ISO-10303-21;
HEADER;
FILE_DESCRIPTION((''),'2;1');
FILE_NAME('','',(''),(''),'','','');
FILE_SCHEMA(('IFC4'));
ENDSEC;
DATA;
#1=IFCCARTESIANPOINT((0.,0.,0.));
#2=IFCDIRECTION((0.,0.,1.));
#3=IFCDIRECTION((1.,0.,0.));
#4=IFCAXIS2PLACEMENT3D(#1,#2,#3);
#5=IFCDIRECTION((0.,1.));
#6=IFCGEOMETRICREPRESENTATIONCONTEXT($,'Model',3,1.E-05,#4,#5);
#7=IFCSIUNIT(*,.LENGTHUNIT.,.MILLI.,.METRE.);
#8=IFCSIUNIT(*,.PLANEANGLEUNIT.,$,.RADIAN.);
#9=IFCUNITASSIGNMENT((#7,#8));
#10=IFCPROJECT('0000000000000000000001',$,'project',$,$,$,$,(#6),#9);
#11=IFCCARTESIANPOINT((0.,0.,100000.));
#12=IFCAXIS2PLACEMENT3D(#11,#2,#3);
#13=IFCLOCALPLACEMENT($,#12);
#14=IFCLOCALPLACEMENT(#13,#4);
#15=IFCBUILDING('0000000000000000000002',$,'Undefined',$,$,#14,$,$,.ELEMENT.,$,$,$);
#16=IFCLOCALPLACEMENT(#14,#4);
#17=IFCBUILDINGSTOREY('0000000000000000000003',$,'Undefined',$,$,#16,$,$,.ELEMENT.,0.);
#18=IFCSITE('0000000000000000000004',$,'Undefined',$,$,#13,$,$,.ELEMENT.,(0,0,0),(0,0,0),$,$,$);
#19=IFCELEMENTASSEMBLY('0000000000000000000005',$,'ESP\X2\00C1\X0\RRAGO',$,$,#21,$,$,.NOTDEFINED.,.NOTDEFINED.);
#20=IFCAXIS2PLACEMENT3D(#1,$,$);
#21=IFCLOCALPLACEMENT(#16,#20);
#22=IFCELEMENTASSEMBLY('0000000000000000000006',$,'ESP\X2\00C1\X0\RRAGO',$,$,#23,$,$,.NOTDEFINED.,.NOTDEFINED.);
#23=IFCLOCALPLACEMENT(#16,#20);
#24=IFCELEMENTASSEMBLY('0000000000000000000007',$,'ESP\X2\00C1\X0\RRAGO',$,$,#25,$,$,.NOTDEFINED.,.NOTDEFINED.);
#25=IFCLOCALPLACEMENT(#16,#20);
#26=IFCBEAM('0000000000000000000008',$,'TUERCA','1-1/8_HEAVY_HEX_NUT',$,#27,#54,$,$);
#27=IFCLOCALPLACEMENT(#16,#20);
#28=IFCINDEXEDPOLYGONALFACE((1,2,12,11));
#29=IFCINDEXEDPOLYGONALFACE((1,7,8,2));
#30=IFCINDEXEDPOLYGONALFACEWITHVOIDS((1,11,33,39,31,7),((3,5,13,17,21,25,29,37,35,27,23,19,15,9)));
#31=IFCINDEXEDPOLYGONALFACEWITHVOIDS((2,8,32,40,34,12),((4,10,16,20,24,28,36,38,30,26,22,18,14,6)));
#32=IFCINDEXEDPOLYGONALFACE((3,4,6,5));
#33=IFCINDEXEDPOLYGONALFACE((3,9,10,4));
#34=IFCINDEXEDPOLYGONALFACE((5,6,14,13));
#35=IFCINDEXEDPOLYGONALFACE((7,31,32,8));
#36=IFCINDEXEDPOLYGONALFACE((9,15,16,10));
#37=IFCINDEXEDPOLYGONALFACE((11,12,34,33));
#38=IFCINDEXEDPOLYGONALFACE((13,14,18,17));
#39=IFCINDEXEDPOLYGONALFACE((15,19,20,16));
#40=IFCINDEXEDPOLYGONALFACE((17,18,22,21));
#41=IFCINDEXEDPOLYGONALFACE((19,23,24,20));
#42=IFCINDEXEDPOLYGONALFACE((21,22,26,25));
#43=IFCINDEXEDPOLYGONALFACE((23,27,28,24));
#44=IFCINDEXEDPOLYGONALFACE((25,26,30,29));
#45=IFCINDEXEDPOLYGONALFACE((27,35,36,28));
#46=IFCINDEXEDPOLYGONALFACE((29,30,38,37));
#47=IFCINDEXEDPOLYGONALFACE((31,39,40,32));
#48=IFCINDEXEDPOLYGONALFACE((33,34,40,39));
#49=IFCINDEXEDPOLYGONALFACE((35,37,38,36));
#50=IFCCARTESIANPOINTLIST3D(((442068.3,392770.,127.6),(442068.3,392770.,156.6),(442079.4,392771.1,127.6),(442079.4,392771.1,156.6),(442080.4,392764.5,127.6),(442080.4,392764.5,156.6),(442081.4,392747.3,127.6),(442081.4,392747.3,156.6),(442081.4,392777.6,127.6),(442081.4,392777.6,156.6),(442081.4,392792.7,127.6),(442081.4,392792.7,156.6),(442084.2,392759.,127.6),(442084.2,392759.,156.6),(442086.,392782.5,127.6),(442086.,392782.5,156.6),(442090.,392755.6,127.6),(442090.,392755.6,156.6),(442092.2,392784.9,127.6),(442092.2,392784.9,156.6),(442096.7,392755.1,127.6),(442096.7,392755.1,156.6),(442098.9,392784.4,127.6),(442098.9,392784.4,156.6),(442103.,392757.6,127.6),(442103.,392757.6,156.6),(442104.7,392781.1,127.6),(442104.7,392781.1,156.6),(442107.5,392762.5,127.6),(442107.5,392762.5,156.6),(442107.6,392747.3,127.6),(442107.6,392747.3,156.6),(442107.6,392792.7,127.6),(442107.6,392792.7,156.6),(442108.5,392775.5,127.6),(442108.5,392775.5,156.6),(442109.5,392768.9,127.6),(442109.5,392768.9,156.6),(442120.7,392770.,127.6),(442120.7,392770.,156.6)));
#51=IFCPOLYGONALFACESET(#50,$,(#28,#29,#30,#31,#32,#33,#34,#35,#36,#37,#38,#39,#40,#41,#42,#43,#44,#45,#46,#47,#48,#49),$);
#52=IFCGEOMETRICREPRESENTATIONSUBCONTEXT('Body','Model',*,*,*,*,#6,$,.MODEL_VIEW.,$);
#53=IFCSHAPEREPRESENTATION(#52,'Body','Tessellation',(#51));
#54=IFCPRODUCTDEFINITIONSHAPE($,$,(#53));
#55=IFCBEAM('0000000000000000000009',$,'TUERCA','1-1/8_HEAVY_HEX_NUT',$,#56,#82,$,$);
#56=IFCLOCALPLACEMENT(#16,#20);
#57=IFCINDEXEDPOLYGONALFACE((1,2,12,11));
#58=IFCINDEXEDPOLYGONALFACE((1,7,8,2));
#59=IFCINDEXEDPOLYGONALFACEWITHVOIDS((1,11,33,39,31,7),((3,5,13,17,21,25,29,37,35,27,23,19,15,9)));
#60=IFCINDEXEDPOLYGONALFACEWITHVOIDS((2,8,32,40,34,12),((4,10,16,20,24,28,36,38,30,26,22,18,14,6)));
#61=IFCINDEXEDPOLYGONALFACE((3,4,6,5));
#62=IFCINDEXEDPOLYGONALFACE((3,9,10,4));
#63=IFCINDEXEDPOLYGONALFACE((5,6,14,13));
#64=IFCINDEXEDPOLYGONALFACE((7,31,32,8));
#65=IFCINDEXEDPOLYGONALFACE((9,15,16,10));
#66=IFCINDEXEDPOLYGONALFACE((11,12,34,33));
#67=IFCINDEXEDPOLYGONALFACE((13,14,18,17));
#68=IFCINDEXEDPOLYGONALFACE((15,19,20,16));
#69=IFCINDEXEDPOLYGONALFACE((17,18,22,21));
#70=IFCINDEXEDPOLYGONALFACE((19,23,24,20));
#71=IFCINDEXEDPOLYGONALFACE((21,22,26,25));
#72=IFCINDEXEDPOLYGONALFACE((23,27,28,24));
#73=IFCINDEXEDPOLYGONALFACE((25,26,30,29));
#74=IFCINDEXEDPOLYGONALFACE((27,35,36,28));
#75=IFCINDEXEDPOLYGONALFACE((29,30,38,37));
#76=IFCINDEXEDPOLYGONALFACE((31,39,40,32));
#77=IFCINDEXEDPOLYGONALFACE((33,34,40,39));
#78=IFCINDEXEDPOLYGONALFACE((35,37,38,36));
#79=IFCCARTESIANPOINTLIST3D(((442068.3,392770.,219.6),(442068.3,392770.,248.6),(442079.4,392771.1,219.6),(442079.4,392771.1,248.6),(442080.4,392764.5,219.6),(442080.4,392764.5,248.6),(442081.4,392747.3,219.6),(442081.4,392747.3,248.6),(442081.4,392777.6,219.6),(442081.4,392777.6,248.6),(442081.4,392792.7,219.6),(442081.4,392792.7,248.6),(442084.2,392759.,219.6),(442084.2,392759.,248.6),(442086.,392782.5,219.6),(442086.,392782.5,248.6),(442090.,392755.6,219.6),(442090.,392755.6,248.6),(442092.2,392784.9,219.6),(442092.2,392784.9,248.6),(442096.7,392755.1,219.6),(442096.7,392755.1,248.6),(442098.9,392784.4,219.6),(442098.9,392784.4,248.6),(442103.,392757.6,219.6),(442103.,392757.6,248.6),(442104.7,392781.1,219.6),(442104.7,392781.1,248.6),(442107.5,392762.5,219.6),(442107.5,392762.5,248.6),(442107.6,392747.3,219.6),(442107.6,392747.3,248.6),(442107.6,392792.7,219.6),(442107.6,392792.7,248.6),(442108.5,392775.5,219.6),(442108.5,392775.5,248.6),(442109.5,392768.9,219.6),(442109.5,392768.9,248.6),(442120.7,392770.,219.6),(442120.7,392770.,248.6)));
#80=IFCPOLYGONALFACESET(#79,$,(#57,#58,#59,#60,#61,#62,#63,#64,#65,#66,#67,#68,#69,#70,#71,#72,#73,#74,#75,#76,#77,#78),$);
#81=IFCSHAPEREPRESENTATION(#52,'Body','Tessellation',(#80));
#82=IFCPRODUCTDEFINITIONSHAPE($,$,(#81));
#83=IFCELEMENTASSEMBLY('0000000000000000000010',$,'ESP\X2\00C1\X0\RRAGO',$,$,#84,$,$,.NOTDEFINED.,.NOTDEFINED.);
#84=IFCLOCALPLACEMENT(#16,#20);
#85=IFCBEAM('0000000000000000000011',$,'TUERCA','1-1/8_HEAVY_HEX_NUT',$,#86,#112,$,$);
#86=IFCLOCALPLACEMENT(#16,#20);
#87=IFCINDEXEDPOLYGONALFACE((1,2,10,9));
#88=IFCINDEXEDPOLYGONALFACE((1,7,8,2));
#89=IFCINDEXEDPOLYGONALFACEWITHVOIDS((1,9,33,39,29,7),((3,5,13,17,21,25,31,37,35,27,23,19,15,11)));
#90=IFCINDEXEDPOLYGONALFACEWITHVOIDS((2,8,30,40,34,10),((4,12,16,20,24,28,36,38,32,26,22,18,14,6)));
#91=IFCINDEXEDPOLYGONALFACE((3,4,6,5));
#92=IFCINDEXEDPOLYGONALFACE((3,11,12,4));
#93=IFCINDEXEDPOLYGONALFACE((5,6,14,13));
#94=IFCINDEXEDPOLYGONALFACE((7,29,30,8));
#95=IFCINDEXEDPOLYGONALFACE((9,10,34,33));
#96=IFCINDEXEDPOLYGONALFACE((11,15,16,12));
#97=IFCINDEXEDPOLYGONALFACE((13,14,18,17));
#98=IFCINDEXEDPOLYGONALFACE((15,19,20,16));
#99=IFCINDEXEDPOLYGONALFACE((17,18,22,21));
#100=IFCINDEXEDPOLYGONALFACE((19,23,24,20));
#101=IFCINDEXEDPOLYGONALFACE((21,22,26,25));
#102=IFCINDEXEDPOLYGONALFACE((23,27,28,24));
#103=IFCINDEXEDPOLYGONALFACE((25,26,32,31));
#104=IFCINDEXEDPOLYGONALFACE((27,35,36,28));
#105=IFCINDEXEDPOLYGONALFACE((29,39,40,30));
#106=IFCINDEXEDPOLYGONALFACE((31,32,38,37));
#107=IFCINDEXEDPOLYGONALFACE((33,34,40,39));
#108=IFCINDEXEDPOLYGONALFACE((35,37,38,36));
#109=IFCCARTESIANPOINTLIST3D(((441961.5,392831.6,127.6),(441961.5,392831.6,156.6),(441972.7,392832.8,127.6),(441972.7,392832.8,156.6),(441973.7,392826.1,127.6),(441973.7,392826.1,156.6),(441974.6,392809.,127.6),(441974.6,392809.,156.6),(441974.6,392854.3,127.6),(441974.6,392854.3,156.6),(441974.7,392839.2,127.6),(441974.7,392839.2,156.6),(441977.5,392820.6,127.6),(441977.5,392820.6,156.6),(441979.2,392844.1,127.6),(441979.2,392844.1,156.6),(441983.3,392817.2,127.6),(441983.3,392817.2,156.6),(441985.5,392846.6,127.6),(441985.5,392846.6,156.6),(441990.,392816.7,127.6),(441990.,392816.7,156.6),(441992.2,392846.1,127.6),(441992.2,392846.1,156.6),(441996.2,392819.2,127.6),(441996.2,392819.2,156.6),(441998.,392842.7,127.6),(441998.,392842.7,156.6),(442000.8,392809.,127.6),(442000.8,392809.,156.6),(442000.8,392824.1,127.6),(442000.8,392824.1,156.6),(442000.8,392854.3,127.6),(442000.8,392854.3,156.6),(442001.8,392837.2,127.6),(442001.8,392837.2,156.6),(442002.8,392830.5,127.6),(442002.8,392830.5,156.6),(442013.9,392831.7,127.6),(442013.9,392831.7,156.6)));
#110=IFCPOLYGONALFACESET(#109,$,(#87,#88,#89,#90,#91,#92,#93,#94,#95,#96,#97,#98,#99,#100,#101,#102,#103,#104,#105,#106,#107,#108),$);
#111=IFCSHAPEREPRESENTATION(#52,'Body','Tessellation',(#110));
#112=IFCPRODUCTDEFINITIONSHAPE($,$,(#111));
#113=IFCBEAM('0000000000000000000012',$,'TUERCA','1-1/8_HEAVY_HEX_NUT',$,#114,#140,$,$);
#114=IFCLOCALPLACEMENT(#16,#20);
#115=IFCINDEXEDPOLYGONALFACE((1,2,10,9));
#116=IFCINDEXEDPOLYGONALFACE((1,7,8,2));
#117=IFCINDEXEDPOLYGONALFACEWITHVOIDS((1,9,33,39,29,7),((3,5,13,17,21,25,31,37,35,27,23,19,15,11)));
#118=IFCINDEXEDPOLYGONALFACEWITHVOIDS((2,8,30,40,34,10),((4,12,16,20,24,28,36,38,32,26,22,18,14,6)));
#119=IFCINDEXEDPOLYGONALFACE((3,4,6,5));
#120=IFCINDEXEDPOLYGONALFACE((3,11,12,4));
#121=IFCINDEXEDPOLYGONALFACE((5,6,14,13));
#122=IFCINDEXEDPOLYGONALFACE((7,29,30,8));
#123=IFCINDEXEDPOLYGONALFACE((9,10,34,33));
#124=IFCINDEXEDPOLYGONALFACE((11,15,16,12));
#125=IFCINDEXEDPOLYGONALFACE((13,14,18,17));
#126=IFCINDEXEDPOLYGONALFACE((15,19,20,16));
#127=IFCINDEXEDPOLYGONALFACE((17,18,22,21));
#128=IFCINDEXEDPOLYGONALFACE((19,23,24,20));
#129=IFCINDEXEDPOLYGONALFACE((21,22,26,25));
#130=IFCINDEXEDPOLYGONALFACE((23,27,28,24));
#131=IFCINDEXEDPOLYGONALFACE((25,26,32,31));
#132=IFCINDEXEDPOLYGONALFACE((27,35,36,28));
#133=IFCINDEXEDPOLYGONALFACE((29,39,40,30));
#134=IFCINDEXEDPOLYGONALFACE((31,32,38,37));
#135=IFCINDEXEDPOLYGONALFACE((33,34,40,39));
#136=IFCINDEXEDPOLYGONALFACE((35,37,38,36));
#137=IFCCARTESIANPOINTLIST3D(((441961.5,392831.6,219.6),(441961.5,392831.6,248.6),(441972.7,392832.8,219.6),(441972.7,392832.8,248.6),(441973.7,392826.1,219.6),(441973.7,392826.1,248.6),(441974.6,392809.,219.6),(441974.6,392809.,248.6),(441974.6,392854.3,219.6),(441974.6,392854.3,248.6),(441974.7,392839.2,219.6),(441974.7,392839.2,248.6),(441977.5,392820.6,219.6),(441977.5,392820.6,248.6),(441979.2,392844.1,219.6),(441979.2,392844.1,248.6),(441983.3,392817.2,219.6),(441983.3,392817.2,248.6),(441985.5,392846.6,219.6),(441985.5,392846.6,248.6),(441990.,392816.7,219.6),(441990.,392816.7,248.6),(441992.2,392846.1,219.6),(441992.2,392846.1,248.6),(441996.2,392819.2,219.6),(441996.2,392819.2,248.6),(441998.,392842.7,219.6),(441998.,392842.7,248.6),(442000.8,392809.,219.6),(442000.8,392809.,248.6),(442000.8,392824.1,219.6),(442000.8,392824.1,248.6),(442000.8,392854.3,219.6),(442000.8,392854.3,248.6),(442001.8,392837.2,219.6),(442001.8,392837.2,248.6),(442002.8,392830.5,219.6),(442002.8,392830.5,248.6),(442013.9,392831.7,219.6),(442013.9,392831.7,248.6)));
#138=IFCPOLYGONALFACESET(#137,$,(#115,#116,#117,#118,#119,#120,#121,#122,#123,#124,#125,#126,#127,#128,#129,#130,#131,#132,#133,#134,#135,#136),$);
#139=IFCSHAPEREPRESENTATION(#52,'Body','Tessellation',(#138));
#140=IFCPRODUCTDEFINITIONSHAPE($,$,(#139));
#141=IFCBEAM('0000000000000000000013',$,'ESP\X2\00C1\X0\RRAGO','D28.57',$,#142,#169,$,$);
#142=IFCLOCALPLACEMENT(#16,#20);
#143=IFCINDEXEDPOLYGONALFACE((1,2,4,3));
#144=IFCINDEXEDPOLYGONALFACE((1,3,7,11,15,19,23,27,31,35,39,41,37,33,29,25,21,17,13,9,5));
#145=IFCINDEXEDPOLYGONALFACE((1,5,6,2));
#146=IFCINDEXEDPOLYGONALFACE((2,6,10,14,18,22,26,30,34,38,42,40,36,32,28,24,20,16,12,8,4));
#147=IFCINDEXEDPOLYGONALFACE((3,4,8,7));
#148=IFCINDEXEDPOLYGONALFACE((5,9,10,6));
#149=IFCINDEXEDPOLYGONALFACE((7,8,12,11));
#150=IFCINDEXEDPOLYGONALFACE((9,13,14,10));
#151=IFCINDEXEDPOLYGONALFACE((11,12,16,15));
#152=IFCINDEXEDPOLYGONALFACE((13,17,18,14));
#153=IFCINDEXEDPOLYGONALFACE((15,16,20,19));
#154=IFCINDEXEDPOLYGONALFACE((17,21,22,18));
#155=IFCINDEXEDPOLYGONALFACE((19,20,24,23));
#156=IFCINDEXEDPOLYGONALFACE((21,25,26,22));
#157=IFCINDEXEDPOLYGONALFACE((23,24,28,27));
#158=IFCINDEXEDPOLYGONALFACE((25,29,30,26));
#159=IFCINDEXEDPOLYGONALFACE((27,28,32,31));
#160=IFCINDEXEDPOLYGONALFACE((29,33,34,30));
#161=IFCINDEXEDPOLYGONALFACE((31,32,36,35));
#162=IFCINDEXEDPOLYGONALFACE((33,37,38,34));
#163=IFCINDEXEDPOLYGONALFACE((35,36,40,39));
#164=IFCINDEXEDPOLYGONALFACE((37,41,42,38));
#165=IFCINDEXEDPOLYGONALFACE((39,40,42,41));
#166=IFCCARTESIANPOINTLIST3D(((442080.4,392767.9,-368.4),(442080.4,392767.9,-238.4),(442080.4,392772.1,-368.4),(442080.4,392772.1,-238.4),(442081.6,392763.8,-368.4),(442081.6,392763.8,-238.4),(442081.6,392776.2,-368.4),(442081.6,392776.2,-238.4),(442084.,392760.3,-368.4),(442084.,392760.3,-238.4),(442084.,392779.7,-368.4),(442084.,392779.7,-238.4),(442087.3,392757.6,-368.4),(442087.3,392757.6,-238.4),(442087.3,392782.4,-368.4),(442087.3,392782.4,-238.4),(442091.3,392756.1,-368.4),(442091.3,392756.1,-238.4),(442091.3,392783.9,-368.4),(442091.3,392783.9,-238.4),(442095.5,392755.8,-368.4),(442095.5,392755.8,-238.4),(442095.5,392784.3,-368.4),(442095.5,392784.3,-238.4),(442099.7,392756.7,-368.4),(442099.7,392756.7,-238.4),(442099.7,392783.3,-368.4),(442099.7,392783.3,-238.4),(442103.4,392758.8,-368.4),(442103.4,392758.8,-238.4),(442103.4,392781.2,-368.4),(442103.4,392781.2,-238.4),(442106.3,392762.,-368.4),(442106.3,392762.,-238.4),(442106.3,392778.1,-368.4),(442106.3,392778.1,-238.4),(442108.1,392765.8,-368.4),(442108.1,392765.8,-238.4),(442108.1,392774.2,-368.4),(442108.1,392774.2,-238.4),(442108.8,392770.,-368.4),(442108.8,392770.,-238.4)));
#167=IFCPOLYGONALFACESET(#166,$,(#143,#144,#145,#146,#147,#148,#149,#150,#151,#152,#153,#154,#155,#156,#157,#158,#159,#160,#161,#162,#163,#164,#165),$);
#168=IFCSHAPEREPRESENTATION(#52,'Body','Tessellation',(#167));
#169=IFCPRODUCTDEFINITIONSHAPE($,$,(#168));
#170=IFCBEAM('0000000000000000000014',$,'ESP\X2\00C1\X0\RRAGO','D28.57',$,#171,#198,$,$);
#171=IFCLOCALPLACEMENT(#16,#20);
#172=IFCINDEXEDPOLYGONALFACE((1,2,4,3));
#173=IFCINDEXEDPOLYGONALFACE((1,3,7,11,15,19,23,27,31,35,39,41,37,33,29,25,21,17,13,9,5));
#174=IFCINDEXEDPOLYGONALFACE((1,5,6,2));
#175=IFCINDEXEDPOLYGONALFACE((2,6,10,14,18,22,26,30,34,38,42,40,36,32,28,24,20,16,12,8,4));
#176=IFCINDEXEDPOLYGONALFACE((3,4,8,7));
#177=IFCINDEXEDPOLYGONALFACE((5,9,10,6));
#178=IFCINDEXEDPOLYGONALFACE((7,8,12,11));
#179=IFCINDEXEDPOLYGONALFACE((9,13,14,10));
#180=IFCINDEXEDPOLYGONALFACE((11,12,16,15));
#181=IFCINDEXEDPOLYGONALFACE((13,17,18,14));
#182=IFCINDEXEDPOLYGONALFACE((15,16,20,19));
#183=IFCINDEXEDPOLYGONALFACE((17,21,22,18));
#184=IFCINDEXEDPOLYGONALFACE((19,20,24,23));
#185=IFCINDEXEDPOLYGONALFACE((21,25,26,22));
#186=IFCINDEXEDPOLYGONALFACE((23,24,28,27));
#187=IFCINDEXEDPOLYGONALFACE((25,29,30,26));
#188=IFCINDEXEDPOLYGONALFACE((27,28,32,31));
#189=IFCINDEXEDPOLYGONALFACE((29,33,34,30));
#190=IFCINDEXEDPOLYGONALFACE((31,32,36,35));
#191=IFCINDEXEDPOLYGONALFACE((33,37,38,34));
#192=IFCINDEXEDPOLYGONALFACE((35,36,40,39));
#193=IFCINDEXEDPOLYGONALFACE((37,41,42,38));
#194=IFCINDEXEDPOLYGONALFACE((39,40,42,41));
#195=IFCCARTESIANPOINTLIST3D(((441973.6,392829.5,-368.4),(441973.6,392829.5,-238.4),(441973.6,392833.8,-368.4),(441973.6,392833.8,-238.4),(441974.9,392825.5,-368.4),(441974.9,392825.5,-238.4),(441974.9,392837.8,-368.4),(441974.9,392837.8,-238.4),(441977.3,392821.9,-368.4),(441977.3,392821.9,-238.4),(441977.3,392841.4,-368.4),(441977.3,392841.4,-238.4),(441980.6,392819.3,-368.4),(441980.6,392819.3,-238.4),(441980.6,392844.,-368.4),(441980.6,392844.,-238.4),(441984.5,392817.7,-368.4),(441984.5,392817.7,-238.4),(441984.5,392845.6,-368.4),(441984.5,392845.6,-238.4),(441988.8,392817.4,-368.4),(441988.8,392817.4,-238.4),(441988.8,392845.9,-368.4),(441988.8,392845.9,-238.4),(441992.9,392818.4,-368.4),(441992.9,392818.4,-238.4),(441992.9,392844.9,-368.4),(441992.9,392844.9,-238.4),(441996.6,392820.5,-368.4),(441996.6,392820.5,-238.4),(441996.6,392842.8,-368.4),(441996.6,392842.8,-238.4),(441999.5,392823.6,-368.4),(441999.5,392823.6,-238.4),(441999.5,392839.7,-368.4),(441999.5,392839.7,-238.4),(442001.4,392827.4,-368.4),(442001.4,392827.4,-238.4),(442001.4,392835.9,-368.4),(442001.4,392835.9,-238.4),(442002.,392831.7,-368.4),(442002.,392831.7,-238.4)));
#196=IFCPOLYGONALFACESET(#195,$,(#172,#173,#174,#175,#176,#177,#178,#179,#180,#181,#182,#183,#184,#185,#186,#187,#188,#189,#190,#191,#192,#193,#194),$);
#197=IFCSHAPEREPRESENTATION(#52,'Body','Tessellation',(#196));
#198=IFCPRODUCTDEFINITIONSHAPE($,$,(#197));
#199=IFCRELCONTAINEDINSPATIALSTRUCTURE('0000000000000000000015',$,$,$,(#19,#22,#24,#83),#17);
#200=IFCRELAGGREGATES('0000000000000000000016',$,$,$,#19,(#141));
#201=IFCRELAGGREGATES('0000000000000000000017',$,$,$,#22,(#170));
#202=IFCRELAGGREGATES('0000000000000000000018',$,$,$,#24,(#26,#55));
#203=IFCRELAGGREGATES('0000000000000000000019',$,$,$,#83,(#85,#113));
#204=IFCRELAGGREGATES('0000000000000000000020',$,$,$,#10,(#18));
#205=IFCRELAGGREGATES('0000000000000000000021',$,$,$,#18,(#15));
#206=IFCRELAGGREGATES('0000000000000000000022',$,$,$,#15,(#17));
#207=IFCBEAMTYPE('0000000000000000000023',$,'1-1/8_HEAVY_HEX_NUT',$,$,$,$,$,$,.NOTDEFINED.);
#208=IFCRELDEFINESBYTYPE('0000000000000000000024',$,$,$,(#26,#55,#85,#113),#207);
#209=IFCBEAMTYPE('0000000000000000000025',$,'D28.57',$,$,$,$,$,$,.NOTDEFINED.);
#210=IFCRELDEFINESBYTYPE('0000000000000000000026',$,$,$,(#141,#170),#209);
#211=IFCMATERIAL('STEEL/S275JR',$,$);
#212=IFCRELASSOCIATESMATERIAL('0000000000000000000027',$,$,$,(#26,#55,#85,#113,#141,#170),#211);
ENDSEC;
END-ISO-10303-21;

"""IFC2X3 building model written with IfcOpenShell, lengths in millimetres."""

from ifc_helpers import new_model, si_unit, direction, frame, origin_with_axes, origin_2d_with_axis, place, context, subcontext, project, spatial, polyline, circle, outline, extrude, material, type_object, element, aggregate, save


model = new_model("IFC2X3")

# Units and contexts
model_context = context("Model", 3, precision=1e-05, world=origin_with_axes(), true_north=direction((0.0, 1.0)))
body_context = subcontext(model_context, "Body", "Model", "MODEL_VIEW")
ifc_project = project(units=[si_unit("LENGTHUNIT", "METRE", prefix="MILLI"), si_unit("PLANEANGLEUNIT", "RADIAN")], contexts=[model_context])

# Site, building, storey
site_placement = place(None, frame((0.0, 0.0, 100000.0), z_axis=(0.0, 0.0, 1.0), x_axis=(1.0, 0.0, 0.0)))
site = spatial("IfcSite", under=ifc_project, at=site_placement, Name="Undefined", CompositionType="ELEMENT", RefLatitude=(0, 0, 0), RefLongitude=(0, 0, 0))
building_placement = place(site_placement, origin_with_axes())
building = spatial("IfcBuilding", under=site, at=building_placement, Name="Undefined", CompositionType="ELEMENT")
storey_placement = place(building_placement, origin_with_axes())
storey = spatial("IfcBuildingStorey", under=building, at=storey_placement, Name="Undefined", CompositionType="ELEMENT", Elevation=0.0)

# Shared definitions
ifc_material_1 = material(Name="STEEL/S275JR")

# Element assemblies
assembly_1_placement = place(storey_placement, origin_with_axes())
assembly_1 = element("IfcElementAssembly", 1, at=assembly_1_placement, inside=storey, Name="ESPÁRRAGO", AssemblyPlace="NOTDEFINED", PredefinedType="NOTDEFINED")
beam_type_1 = type_object("IfcBeamType", Name="1-1/8_HEAVY_HEX_NUT", PredefinedType="NOTDEFINED")
assembly_2_placement = place(storey_placement, origin_with_axes())
assembly_2 = element("IfcElementAssembly", 2, at=assembly_2_placement, inside=storey, Name="ESPÁRRAGO", AssemblyPlace="NOTDEFINED", PredefinedType="NOTDEFINED")

# Element assemblies, beams
assembly_3_placement = place(storey_placement, origin_with_axes())
assembly_3 = element("IfcElementAssembly", 3, at=assembly_3_placement, inside=storey, Name="ESPÁRRAGO", AssemblyPlace="NOTDEFINED", PredefinedType="NOTDEFINED")
beam_1_placement = place(assembly_3_placement, frame((442094.5, 392770.0, 156.6), z_axis=(0.866025, -0.5, 0.0), x_axis=(0.0, 0.0, -1.0)))
beam_1 = element("IfcBeam", 4, at=beam_1_placement, type_object=beam_type_1, material=ifc_material_1, Name="TUERCA", Description="1-1/8_HEAVY_HEX_NUT", context=body_context, shape_type="SweptSolid", body=[
    extrude(outline(polyline([(-13.1, -22.7), (-26.2, 0.0), (-13.1, 22.7), (13.1, 22.7), (26.2, 0.0), (13.1, -22.7), (-13.1, -22.7)]), holes=[polyline([(6.5, 13.6), (0.0, 15.1), (-6.5, 13.6), (-11.8, 9.4), (-14.7, 3.4), (-14.7, -3.4), (-11.8, -9.4), (-6.5, -13.6), (0.0, -15.1), (6.5, -13.6), (11.8, -9.4), (14.7, -3.4), (14.7, 3.4), (11.8, 9.4), (6.5, 13.6)])]), frame((29.0, 0.0, 0.0), z_axis=(-1.0, 0.0, 0.0), x_axis=(0.0, -1.0, 0.0)), (0.0, 0.0, 1.0), 29.0),
])
beam_2_placement = place(assembly_3_placement, frame((442094.5, 392770.0, 248.6), z_axis=(0.866025, -0.5, 0.0), x_axis=(0.0, 0.0, -1.0)))
beam_2 = element("IfcBeam", 5, at=beam_2_placement, type_object=beam_type_1, material=ifc_material_1, Name="TUERCA", Description="1-1/8_HEAVY_HEX_NUT", context=body_context, shape_type="SweptSolid", body=[
    extrude(outline(polyline([(-13.1, -22.7), (-26.2, 0.0), (-13.1, 22.7), (13.1, 22.7), (26.2, 0.0), (13.1, -22.7), (-13.1, -22.7)]), holes=[polyline([(6.5, 13.6), (0.0, 15.1), (-6.5, 13.6), (-11.8, 9.4), (-14.7, 3.4), (-14.7, -3.4), (-11.8, -9.4), (-6.5, -13.6), (0.0, -15.1), (6.5, -13.6), (11.8, -9.4), (14.7, -3.4), (14.7, 3.4), (11.8, 9.4), (6.5, 13.6)])]), frame((29.0, 0.0, 0.0), z_axis=(-1.0, 0.0, 0.0), x_axis=(0.0, -1.0, 0.0)), (0.0, 0.0, 1.0), 29.0),
])
assembly_4_placement = place(storey_placement, origin_with_axes())
assembly_4 = element("IfcElementAssembly", 6, at=assembly_4_placement, inside=storey, Name="ESPÁRRAGO", AssemblyPlace="NOTDEFINED", PredefinedType="NOTDEFINED")
beam_3_placement = place(assembly_4_placement, frame((441987.7, 392831.7, 156.6), z_axis=(0.866025, -0.5, 0.0), x_axis=(0.0, 0.0, -1.0)))
beam_3 = element("IfcBeam", 7, at=beam_3_placement, type_object=beam_type_1, material=ifc_material_1, Name="TUERCA", Description="1-1/8_HEAVY_HEX_NUT", context=body_context, shape_type="SweptSolid", body=[
    extrude(outline(polyline([(-13.1, -22.7), (-26.2, 0.0), (-13.1, 22.7), (13.1, 22.7), (26.2, 0.0), (13.1, -22.7), (-13.1, -22.7)]), holes=[polyline([(6.5, 13.6), (0.0, 15.1), (-6.5, 13.6), (-11.8, 9.4), (-14.7, 3.4), (-14.7, -3.4), (-11.8, -9.4), (-6.5, -13.6), (0.0, -15.1), (6.5, -13.6), (11.8, -9.4), (14.7, -3.4), (14.7, 3.4), (11.8, 9.4), (6.5, 13.6)])]), frame((29.0, 0.0, 0.0), z_axis=(-1.0, 0.0, 0.0), x_axis=(0.0, -1.0, 0.0)), (0.0, 0.0, 1.0), 29.0),
])
beam_4_placement = place(assembly_4_placement, frame((441987.7, 392831.7, 248.6), z_axis=(0.866025, -0.5, 0.0), x_axis=(0.0, 0.0, -1.0)))
beam_4 = element("IfcBeam", 8, at=beam_4_placement, type_object=beam_type_1, material=ifc_material_1, Name="TUERCA", Description="1-1/8_HEAVY_HEX_NUT", context=body_context, shape_type="SweptSolid", body=[
    extrude(outline(polyline([(-13.1, -22.7), (-26.2, 0.0), (-13.1, 22.7), (13.1, 22.7), (26.2, 0.0), (13.1, -22.7), (-13.1, -22.7)]), holes=[polyline([(6.5, 13.6), (0.0, 15.1), (-6.5, 13.6), (-11.8, 9.4), (-14.7, 3.4), (-14.7, -3.4), (-11.8, -9.4), (-6.5, -13.6), (0.0, -15.1), (6.5, -13.6), (11.8, -9.4), (14.7, -3.4), (14.7, 3.4), (11.8, 9.4), (6.5, 13.6)])]), frame((29.0, 0.0, 0.0), z_axis=(-1.0, 0.0, 0.0), x_axis=(0.0, -1.0, 0.0)), (0.0, 0.0, 1.0), 29.0),
])

# Beams
beam_type_2 = type_object("IfcBeamType", Name="D28.57", PredefinedType="NOTDEFINED")
beam_5_placement = place(assembly_1_placement, frame((442094.5, 392770.0, -238.4), z_axis=(0.866025, -0.5, 0.0), x_axis=(0.0, 0.0, -1.0)))
beam_5 = element("IfcBeam", 9, at=beam_5_placement, type_object=beam_type_2, material=ifc_material_1, Name="ESPÁRRAGO", Description="D28.57", context=body_context, shape_type="SweptSolid", body=[
    extrude(circle(Radius=14.3, at=origin_2d_with_axis()), frame((130.0, 0.0, 0.0), z_axis=(-1.0, 0.0, 0.0), x_axis=(0.0, -1.0, 0.0)), (0.0, 0.0, 1.0), 130.0),
])
aggregate(assembly_1, [beam_5])
beam_6_placement = place(assembly_2_placement, frame((441987.7, 392831.7, -238.4), z_axis=(0.866025, -0.5, 0.0), x_axis=(0.0, 0.0, -1.0)))
beam_6 = element("IfcBeam", 10, at=beam_6_placement, type_object=beam_type_2, material=ifc_material_1, Name="ESPÁRRAGO", Description="D28.57", context=body_context, shape_type="SweptSolid", body=[
    extrude(circle(Radius=14.3, at=origin_2d_with_axis()), frame((130.0, 0.0, 0.0), z_axis=(-1.0, 0.0, 0.0), x_axis=(0.0, -1.0, 0.0)), (0.0, 0.0, 1.0), 130.0),
])
aggregate(assembly_2, [beam_6])
aggregate(assembly_3, [beam_1, beam_2])
aggregate(assembly_4, [beam_3, beam_4])

save(model, "model.ifc")
